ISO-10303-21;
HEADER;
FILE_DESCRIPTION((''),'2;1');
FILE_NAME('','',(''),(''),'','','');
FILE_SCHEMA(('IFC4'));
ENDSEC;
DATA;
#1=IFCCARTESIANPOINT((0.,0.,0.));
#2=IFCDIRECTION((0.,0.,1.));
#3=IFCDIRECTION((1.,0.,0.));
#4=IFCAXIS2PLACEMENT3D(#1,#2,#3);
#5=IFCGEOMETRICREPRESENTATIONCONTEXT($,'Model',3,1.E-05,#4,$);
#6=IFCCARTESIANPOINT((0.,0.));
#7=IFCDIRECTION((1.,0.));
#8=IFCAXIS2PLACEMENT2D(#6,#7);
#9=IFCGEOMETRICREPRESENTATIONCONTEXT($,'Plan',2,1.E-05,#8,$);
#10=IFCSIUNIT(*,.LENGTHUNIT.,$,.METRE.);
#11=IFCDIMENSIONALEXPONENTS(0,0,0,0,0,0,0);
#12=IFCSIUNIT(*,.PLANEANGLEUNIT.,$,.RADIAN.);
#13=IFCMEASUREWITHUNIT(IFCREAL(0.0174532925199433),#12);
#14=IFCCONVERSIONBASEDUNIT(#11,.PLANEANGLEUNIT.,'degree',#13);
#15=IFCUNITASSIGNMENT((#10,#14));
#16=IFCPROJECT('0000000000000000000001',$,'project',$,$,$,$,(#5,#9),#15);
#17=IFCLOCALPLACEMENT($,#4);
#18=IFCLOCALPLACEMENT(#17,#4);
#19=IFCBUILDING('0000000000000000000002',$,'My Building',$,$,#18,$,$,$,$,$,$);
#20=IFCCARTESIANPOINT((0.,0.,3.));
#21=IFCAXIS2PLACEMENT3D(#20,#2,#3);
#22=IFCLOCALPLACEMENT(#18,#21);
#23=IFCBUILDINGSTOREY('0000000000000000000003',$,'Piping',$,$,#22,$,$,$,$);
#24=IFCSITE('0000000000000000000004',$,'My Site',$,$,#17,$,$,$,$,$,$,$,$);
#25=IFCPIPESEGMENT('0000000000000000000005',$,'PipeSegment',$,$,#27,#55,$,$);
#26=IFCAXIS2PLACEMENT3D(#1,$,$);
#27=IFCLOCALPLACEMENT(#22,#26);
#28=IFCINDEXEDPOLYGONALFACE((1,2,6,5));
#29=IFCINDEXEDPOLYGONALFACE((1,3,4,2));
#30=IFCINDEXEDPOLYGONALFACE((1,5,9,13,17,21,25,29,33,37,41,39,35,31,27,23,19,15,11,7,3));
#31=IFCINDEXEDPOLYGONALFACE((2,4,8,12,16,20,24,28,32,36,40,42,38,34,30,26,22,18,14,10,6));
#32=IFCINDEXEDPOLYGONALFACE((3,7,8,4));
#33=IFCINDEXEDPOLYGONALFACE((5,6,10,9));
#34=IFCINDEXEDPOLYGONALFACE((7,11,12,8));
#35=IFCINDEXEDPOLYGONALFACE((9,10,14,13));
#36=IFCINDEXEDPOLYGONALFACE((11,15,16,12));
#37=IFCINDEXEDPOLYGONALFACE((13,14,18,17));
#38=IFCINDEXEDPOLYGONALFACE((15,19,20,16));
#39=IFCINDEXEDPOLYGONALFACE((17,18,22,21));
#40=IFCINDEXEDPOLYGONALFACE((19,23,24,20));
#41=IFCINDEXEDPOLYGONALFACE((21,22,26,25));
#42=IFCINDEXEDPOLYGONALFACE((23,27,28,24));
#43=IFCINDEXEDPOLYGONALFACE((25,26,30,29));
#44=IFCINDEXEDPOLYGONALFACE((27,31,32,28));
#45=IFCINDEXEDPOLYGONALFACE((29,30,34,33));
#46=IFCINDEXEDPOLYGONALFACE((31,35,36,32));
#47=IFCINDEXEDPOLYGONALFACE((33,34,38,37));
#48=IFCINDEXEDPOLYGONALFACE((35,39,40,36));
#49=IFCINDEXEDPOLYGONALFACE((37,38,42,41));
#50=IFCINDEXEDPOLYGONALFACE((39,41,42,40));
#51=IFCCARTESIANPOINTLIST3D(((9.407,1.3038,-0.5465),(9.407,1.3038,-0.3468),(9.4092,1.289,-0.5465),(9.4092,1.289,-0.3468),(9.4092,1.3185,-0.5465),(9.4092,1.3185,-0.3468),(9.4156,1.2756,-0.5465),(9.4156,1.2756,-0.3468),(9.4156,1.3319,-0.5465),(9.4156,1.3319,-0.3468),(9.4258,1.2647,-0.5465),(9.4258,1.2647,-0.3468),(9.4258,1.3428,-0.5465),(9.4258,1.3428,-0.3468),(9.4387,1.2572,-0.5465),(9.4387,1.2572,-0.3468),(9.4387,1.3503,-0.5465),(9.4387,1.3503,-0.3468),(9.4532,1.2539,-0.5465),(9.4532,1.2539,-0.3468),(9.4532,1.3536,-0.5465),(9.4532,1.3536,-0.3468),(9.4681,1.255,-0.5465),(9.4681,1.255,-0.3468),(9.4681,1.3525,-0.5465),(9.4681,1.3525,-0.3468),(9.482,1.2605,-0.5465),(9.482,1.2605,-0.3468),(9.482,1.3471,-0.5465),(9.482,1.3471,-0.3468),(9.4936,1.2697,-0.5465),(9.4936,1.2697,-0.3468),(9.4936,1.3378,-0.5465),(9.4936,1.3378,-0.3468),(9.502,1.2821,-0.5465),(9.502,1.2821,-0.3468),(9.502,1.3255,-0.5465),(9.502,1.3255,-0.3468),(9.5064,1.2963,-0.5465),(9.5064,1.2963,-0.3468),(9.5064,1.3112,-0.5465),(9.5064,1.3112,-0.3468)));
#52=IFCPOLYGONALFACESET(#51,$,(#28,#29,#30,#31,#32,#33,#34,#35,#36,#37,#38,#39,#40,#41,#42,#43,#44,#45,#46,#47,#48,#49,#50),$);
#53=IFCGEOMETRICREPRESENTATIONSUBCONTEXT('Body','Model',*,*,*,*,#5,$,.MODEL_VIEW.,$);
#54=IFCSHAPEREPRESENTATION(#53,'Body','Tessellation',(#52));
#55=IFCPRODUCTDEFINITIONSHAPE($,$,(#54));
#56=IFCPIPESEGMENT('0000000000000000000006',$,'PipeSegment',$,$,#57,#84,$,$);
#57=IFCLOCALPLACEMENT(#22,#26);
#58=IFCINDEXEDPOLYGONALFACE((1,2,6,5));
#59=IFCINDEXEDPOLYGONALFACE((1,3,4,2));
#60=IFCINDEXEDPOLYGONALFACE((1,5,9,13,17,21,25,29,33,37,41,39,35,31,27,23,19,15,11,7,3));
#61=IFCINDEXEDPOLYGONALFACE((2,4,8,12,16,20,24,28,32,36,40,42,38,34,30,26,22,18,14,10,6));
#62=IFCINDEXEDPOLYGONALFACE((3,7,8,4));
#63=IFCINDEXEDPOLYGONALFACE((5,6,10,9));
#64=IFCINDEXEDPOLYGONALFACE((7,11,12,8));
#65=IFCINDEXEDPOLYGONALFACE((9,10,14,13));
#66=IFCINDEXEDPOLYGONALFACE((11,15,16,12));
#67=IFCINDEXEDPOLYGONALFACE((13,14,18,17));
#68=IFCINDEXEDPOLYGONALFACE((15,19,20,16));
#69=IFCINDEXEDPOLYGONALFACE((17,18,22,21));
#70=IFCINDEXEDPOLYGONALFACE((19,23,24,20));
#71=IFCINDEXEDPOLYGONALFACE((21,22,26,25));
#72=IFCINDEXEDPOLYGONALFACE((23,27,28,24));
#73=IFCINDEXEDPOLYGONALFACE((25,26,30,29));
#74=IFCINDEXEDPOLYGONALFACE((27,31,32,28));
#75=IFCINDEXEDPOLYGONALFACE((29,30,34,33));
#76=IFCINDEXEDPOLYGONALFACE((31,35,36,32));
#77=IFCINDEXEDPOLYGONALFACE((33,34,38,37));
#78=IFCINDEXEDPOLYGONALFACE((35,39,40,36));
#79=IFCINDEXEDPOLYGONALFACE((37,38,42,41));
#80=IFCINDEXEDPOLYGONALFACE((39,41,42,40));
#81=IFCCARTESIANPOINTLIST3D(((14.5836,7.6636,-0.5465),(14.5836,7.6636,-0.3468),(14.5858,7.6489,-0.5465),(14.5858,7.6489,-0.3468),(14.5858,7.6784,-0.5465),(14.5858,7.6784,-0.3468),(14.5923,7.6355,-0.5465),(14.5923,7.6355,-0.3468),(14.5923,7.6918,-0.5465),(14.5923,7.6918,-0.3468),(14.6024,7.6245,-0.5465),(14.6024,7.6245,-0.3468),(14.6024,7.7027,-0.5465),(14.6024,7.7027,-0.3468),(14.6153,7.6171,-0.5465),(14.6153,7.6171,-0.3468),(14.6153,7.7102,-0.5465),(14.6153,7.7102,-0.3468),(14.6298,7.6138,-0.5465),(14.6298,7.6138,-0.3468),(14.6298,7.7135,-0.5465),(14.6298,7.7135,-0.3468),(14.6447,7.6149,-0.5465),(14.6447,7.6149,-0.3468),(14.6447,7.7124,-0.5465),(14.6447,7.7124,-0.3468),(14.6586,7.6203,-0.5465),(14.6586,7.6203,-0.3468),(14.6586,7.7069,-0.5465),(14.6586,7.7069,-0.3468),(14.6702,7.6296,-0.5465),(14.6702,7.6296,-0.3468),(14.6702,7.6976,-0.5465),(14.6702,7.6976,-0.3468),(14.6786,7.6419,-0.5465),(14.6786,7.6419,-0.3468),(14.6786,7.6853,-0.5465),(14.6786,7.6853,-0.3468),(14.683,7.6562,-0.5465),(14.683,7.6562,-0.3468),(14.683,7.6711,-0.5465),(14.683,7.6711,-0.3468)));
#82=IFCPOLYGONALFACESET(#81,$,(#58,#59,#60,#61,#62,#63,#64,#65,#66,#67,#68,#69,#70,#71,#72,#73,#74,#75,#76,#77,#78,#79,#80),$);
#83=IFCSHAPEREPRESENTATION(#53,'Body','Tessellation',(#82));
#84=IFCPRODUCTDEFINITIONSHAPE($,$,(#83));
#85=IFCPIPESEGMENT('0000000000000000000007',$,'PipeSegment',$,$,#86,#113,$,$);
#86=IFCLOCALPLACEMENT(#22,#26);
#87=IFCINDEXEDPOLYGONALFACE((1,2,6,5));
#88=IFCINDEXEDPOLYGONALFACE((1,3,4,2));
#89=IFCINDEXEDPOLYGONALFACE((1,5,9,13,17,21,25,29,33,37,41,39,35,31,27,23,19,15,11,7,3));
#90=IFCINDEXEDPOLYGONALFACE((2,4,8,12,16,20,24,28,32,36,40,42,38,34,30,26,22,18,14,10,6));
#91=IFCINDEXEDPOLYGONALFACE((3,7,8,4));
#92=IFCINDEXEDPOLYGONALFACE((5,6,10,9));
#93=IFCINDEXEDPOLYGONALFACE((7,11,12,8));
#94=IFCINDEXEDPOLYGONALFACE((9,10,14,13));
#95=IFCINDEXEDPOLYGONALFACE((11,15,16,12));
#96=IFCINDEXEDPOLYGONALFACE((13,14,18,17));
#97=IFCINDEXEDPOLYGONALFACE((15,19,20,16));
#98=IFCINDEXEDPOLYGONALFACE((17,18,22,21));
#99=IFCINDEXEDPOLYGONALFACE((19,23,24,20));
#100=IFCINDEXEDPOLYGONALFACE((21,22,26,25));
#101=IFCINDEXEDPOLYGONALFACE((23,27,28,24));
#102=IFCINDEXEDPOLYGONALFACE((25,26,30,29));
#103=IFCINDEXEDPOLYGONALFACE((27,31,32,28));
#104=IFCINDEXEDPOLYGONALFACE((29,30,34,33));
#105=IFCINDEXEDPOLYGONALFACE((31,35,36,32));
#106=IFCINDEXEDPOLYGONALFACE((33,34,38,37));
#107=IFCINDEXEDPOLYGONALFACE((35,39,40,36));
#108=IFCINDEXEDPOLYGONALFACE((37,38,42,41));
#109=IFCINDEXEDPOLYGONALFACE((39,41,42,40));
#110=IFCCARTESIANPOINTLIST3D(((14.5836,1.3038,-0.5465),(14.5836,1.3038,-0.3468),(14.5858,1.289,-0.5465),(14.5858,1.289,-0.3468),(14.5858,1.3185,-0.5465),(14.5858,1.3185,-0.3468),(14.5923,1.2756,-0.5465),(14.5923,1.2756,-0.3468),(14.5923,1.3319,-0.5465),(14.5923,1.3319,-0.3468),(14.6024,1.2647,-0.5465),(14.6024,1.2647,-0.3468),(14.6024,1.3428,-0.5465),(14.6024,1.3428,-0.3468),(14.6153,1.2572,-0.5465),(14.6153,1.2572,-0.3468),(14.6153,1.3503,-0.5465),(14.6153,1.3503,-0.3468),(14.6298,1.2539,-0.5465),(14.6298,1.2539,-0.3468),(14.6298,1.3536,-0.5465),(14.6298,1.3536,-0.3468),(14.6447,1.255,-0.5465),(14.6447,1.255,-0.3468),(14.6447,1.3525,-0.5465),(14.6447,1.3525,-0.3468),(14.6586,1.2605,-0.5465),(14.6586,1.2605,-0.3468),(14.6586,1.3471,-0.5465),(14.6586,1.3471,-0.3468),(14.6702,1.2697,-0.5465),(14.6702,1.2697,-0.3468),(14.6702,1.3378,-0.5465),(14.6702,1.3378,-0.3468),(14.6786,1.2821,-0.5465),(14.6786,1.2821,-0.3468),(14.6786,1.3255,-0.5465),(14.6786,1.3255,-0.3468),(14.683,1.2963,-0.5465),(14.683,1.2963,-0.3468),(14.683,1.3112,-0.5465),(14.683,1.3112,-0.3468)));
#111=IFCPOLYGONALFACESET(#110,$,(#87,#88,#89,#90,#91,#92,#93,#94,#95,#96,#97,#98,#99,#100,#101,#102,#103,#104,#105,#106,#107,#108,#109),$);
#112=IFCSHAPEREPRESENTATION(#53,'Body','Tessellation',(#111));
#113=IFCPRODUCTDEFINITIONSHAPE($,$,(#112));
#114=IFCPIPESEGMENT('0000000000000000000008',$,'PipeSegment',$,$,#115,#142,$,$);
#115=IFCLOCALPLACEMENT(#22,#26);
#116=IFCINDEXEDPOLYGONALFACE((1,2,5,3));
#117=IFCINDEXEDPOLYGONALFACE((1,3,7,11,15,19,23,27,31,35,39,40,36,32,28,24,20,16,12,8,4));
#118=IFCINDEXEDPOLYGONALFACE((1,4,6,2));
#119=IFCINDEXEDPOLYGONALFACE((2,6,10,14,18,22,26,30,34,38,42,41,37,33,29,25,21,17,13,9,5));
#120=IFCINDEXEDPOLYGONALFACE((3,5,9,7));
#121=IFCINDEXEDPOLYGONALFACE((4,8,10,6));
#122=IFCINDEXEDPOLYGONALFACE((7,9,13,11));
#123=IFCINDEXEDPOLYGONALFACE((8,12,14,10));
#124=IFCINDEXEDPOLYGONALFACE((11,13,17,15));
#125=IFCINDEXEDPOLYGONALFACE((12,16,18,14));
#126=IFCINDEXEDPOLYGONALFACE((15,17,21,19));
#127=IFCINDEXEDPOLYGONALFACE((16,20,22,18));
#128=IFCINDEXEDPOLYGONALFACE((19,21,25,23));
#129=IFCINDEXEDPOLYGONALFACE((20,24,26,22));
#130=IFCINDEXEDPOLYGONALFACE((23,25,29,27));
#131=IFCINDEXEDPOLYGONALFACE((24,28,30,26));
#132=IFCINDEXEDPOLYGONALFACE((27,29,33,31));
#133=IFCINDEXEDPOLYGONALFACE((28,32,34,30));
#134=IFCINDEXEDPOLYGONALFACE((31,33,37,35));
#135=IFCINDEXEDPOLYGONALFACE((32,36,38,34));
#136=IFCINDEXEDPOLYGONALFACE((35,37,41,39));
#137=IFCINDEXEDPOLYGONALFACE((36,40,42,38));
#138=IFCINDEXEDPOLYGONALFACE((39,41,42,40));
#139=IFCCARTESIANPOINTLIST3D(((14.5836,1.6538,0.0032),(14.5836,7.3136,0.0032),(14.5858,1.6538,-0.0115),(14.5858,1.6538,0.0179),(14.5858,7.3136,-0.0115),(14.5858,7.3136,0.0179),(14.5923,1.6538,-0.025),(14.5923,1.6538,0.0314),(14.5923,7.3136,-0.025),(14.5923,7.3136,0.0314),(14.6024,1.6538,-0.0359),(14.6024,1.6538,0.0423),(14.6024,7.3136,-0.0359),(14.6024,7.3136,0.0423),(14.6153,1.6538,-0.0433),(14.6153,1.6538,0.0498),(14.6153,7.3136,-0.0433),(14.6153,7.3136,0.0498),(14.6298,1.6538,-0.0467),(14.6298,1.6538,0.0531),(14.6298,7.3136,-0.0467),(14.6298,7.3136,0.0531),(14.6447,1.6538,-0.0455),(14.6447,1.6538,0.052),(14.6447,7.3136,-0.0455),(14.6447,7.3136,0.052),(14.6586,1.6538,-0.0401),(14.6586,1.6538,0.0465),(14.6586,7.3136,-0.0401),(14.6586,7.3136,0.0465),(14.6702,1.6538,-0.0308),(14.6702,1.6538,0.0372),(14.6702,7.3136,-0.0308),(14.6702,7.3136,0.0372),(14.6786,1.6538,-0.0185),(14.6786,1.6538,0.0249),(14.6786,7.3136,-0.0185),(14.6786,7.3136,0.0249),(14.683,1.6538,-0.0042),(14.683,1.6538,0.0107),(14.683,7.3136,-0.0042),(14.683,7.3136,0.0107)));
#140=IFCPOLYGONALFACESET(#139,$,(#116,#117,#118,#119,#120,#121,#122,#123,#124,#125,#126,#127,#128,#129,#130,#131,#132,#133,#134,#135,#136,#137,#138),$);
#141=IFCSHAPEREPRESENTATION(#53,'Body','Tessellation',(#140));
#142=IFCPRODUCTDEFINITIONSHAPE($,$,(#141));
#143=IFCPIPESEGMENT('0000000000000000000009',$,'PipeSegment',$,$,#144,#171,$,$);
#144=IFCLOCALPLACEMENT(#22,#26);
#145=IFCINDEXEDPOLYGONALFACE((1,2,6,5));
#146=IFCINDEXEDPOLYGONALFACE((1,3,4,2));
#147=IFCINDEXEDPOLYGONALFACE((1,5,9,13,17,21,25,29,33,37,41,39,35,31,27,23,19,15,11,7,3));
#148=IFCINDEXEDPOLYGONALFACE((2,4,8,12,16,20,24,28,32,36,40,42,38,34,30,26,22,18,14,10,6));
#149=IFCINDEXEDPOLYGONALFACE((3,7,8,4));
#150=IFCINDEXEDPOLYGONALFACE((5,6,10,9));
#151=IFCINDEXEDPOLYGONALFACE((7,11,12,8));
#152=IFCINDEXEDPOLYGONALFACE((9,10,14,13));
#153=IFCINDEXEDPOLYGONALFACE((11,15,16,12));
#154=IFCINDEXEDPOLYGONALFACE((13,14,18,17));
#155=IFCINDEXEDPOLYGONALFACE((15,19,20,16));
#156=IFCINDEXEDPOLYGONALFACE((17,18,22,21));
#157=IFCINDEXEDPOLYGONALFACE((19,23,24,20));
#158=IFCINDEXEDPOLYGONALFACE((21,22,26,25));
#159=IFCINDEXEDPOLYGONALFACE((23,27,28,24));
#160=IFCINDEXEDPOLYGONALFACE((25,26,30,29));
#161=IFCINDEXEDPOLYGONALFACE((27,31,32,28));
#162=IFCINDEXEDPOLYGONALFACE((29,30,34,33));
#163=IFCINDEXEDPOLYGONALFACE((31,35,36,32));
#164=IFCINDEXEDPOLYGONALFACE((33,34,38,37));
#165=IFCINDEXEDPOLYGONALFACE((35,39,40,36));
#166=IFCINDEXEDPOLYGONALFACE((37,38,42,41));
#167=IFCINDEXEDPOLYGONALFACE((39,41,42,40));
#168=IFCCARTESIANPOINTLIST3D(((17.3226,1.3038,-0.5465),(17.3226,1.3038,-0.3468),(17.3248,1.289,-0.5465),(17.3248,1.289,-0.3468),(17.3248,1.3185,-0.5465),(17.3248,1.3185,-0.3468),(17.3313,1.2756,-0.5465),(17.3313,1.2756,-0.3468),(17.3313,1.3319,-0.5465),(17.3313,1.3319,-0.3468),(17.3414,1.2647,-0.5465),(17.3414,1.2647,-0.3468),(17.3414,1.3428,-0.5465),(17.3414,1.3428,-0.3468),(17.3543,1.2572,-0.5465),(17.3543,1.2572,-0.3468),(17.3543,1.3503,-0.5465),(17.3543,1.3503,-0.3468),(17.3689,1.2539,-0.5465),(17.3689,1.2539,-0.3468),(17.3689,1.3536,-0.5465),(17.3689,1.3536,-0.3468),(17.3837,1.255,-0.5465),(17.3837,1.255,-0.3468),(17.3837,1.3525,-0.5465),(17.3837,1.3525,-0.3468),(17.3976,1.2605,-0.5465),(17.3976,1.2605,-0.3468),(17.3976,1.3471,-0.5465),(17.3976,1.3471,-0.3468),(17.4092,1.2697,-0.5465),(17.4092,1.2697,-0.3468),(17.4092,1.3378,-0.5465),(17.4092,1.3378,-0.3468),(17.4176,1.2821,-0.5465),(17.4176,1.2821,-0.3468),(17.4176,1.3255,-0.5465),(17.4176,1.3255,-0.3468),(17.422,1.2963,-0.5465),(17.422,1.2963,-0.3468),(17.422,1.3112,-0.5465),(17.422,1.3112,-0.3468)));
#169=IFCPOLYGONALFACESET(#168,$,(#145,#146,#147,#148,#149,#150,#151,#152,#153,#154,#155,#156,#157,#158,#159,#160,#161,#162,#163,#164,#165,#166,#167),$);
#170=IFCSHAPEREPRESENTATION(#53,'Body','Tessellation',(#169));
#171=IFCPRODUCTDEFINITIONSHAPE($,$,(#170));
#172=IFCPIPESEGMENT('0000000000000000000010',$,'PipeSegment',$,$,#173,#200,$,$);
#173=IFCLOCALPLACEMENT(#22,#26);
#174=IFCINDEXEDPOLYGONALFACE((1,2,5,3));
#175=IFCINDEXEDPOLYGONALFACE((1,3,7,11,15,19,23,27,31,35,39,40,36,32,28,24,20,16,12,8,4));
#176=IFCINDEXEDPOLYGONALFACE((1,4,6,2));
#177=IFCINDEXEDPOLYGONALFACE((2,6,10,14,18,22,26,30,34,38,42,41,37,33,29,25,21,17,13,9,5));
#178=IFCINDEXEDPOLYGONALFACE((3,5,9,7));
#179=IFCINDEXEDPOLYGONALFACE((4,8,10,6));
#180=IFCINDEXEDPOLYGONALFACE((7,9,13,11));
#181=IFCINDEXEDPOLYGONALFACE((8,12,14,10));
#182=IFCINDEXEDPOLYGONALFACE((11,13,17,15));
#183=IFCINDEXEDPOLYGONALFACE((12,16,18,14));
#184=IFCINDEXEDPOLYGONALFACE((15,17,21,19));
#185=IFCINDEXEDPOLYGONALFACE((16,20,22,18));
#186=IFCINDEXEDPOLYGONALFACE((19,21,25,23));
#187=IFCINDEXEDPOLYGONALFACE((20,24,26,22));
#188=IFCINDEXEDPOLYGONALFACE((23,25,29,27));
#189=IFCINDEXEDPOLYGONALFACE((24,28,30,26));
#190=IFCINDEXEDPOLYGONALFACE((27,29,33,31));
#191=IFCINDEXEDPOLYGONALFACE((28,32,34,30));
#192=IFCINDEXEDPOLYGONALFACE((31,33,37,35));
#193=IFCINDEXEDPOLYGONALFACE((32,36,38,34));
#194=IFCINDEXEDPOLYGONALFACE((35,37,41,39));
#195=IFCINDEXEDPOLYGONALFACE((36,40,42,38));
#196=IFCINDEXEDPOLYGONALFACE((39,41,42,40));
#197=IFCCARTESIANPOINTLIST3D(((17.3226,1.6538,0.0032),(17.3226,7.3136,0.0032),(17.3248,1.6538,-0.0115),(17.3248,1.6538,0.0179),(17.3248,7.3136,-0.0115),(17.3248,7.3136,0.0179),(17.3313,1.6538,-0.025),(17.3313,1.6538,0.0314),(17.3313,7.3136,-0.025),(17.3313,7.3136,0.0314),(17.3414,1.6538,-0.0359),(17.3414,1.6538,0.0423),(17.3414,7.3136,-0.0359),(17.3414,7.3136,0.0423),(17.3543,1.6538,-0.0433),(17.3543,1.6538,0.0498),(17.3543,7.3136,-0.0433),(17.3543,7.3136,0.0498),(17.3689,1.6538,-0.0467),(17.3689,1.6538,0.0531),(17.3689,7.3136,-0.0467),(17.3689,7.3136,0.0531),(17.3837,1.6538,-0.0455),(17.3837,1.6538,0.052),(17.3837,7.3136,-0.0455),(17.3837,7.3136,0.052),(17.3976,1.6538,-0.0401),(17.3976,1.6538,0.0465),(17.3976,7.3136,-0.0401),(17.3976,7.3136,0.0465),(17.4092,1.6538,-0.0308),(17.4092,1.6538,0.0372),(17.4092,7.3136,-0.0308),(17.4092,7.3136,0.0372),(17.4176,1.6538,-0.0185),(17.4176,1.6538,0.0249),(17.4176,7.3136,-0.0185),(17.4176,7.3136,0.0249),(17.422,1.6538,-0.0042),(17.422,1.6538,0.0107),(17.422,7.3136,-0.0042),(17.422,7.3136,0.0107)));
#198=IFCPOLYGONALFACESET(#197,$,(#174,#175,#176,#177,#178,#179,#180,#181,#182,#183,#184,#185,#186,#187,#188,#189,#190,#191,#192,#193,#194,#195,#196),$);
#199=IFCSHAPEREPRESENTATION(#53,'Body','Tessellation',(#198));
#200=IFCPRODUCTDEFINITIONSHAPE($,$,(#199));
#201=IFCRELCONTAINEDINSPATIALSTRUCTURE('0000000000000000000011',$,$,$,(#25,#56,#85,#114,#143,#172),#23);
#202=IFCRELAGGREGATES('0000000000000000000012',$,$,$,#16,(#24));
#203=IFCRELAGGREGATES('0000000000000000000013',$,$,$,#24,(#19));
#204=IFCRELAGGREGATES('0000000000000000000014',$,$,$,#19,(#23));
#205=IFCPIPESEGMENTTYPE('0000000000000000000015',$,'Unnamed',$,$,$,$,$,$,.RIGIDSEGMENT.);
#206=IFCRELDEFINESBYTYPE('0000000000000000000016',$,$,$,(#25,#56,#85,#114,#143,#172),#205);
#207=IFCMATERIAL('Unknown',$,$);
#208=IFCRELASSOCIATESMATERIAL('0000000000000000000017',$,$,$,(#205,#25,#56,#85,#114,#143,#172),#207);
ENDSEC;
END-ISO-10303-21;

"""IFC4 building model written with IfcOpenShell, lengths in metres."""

from ifc_helpers import new_model, entity, si_unit, converted_unit, frame, origin_with_axes, origin_2d_with_axis, place, context, subcontext, project, spatial, circle, extrude, material, material_profile, profile_set, profile_usage, type_object, element, save


model = new_model("IFC4")

# Units and contexts
model_context = context("Model", 3, precision=1e-05, world=origin_with_axes())
plan_context = context("Plan", 2, precision=1e-05, world=origin_2d_with_axis())
body_context = subcontext(model_context, "Body", "Model", "MODEL_VIEW")
ifc_project = project(units=[si_unit("LENGTHUNIT", "METRE"), converted_unit("PLANEANGLEUNIT", "degree", entity("IfcReal", 0.0174532925199433), si_unit("PLANEANGLEUNIT", "RADIAN"), dimensions=[0, 0, 0, 0, 0, 0, 0])], contexts=[model_context, plan_context])

# Site, building, storey
site_placement = place(None, origin_with_axes())
site = spatial("IfcSite", under=ifc_project, at=site_placement, Name="My Site")
building_placement = place(site_placement, origin_with_axes())
building = spatial("IfcBuilding", under=site, at=building_placement, Name="My Building")
storey_placement = place(building_placement, frame((0.0, 0.0, 3.0), z_axis=(0.0, 0.0, 1.0), x_axis=(1.0, 0.0, 0.0)))
storey = spatial("IfcBuildingStorey", under=building, at=storey_placement, Name="Piping")

# Pipe segments
ifc_material = material(Name="Unknown")
ifc_material_profile = material_profile(ifc_material, circle(Radius=0.05))
ifc_profile_set = profile_set([ifc_material_profile])
pipe_segment_type = type_object("IfcPipeSegmentType", Name="Unnamed", PredefinedType="RIGIDSEGMENT", material=ifc_profile_set)
ifc_profile_usage_1 = profile_usage(ifc_profile_set, cardinal=5)
pipe_segment_1_placement = place(storey_placement, frame((9.457, 1.3038, -0.3468), z_axis=(0.0, 0.0, -1.0), x_axis=(-1.0, 0.0, 0.0)))
element("IfcPipeSegment", 1, at=pipe_segment_1_placement, inside=storey, type_object=pipe_segment_type, material=ifc_profile_usage_1, Name="PipeSegment", context=body_context, shape_type="SweptSolid", body=[
    extrude(circle(Radius=0.05), origin_with_axes(), (0.0, 0.0, 1.0), 0.1997),
])
ifc_profile_usage_2 = profile_usage(ifc_profile_set, cardinal=5)
pipe_segment_2_placement = place(storey_placement, frame((14.6336, 7.6636, -0.3468), z_axis=(0.0, 0.0, -1.0), x_axis=(-1.0, 0.0, 0.0)))
element("IfcPipeSegment", 2, at=pipe_segment_2_placement, inside=storey, type_object=pipe_segment_type, material=ifc_profile_usage_2, Name="PipeSegment", context=body_context, shape_type="SweptSolid", body=[
    extrude(circle(Radius=0.05), origin_with_axes(), (0.0, 0.0, 1.0), 0.1997),
])
ifc_profile_usage_3 = profile_usage(ifc_profile_set, cardinal=5)
pipe_segment_3_placement = place(storey_placement, frame((14.6336, 1.3038, -0.3468), z_axis=(0.0, 0.0, -1.0), x_axis=(-1.0, 0.0, 0.0)))
element("IfcPipeSegment", 3, at=pipe_segment_3_placement, inside=storey, type_object=pipe_segment_type, material=ifc_profile_usage_3, Name="PipeSegment", context=body_context, shape_type="SweptSolid", body=[
    extrude(circle(Radius=0.05), origin_with_axes(), (0.0, 0.0, 1.0), 0.1997),
])
ifc_profile_usage_4 = profile_usage(ifc_profile_set, cardinal=5)
pipe_segment_4_placement = place(storey_placement, frame((14.6336, 1.6538, 0.0032), z_axis=(0.0, 1.0, 0.0), x_axis=(-1.0, 0.0, 0.0)))
element("IfcPipeSegment", 4, at=pipe_segment_4_placement, inside=storey, type_object=pipe_segment_type, material=ifc_profile_usage_4, Name="PipeSegment", context=body_context, shape_type="SweptSolid", body=[
    extrude(circle(Radius=0.05), origin_with_axes(), (0.0, 0.0, 1.0), 5.6599),
])
ifc_profile_usage_5 = profile_usage(ifc_profile_set, cardinal=5)
pipe_segment_5_placement = place(storey_placement, frame((17.3726, 1.3038, -0.3468), z_axis=(0.0, 0.0, -1.0), x_axis=(-1.0, 0.0, 0.0)))
element("IfcPipeSegment", 5, at=pipe_segment_5_placement, inside=storey, type_object=pipe_segment_type, material=ifc_profile_usage_5, Name="PipeSegment", context=body_context, shape_type="SweptSolid", body=[
    extrude(circle(Radius=0.05), origin_with_axes(), (0.0, 0.0, 1.0), 0.1997),
])
ifc_profile_usage_6 = profile_usage(ifc_profile_set, cardinal=5)
pipe_segment_6_placement = place(storey_placement, frame((17.3726, 1.6538, 0.0032), z_axis=(0.0, 1.0, 0.0), x_axis=(-1.0, 0.0, 0.0)))
element("IfcPipeSegment", 6, at=pipe_segment_6_placement, inside=storey, type_object=pipe_segment_type, material=ifc_profile_usage_6, Name="PipeSegment", context=body_context, shape_type="SweptSolid", body=[
    extrude(circle(Radius=0.05), origin_with_axes(), (0.0, 0.0, 1.0), 5.6599),
])

save(model, "model.ifc")
